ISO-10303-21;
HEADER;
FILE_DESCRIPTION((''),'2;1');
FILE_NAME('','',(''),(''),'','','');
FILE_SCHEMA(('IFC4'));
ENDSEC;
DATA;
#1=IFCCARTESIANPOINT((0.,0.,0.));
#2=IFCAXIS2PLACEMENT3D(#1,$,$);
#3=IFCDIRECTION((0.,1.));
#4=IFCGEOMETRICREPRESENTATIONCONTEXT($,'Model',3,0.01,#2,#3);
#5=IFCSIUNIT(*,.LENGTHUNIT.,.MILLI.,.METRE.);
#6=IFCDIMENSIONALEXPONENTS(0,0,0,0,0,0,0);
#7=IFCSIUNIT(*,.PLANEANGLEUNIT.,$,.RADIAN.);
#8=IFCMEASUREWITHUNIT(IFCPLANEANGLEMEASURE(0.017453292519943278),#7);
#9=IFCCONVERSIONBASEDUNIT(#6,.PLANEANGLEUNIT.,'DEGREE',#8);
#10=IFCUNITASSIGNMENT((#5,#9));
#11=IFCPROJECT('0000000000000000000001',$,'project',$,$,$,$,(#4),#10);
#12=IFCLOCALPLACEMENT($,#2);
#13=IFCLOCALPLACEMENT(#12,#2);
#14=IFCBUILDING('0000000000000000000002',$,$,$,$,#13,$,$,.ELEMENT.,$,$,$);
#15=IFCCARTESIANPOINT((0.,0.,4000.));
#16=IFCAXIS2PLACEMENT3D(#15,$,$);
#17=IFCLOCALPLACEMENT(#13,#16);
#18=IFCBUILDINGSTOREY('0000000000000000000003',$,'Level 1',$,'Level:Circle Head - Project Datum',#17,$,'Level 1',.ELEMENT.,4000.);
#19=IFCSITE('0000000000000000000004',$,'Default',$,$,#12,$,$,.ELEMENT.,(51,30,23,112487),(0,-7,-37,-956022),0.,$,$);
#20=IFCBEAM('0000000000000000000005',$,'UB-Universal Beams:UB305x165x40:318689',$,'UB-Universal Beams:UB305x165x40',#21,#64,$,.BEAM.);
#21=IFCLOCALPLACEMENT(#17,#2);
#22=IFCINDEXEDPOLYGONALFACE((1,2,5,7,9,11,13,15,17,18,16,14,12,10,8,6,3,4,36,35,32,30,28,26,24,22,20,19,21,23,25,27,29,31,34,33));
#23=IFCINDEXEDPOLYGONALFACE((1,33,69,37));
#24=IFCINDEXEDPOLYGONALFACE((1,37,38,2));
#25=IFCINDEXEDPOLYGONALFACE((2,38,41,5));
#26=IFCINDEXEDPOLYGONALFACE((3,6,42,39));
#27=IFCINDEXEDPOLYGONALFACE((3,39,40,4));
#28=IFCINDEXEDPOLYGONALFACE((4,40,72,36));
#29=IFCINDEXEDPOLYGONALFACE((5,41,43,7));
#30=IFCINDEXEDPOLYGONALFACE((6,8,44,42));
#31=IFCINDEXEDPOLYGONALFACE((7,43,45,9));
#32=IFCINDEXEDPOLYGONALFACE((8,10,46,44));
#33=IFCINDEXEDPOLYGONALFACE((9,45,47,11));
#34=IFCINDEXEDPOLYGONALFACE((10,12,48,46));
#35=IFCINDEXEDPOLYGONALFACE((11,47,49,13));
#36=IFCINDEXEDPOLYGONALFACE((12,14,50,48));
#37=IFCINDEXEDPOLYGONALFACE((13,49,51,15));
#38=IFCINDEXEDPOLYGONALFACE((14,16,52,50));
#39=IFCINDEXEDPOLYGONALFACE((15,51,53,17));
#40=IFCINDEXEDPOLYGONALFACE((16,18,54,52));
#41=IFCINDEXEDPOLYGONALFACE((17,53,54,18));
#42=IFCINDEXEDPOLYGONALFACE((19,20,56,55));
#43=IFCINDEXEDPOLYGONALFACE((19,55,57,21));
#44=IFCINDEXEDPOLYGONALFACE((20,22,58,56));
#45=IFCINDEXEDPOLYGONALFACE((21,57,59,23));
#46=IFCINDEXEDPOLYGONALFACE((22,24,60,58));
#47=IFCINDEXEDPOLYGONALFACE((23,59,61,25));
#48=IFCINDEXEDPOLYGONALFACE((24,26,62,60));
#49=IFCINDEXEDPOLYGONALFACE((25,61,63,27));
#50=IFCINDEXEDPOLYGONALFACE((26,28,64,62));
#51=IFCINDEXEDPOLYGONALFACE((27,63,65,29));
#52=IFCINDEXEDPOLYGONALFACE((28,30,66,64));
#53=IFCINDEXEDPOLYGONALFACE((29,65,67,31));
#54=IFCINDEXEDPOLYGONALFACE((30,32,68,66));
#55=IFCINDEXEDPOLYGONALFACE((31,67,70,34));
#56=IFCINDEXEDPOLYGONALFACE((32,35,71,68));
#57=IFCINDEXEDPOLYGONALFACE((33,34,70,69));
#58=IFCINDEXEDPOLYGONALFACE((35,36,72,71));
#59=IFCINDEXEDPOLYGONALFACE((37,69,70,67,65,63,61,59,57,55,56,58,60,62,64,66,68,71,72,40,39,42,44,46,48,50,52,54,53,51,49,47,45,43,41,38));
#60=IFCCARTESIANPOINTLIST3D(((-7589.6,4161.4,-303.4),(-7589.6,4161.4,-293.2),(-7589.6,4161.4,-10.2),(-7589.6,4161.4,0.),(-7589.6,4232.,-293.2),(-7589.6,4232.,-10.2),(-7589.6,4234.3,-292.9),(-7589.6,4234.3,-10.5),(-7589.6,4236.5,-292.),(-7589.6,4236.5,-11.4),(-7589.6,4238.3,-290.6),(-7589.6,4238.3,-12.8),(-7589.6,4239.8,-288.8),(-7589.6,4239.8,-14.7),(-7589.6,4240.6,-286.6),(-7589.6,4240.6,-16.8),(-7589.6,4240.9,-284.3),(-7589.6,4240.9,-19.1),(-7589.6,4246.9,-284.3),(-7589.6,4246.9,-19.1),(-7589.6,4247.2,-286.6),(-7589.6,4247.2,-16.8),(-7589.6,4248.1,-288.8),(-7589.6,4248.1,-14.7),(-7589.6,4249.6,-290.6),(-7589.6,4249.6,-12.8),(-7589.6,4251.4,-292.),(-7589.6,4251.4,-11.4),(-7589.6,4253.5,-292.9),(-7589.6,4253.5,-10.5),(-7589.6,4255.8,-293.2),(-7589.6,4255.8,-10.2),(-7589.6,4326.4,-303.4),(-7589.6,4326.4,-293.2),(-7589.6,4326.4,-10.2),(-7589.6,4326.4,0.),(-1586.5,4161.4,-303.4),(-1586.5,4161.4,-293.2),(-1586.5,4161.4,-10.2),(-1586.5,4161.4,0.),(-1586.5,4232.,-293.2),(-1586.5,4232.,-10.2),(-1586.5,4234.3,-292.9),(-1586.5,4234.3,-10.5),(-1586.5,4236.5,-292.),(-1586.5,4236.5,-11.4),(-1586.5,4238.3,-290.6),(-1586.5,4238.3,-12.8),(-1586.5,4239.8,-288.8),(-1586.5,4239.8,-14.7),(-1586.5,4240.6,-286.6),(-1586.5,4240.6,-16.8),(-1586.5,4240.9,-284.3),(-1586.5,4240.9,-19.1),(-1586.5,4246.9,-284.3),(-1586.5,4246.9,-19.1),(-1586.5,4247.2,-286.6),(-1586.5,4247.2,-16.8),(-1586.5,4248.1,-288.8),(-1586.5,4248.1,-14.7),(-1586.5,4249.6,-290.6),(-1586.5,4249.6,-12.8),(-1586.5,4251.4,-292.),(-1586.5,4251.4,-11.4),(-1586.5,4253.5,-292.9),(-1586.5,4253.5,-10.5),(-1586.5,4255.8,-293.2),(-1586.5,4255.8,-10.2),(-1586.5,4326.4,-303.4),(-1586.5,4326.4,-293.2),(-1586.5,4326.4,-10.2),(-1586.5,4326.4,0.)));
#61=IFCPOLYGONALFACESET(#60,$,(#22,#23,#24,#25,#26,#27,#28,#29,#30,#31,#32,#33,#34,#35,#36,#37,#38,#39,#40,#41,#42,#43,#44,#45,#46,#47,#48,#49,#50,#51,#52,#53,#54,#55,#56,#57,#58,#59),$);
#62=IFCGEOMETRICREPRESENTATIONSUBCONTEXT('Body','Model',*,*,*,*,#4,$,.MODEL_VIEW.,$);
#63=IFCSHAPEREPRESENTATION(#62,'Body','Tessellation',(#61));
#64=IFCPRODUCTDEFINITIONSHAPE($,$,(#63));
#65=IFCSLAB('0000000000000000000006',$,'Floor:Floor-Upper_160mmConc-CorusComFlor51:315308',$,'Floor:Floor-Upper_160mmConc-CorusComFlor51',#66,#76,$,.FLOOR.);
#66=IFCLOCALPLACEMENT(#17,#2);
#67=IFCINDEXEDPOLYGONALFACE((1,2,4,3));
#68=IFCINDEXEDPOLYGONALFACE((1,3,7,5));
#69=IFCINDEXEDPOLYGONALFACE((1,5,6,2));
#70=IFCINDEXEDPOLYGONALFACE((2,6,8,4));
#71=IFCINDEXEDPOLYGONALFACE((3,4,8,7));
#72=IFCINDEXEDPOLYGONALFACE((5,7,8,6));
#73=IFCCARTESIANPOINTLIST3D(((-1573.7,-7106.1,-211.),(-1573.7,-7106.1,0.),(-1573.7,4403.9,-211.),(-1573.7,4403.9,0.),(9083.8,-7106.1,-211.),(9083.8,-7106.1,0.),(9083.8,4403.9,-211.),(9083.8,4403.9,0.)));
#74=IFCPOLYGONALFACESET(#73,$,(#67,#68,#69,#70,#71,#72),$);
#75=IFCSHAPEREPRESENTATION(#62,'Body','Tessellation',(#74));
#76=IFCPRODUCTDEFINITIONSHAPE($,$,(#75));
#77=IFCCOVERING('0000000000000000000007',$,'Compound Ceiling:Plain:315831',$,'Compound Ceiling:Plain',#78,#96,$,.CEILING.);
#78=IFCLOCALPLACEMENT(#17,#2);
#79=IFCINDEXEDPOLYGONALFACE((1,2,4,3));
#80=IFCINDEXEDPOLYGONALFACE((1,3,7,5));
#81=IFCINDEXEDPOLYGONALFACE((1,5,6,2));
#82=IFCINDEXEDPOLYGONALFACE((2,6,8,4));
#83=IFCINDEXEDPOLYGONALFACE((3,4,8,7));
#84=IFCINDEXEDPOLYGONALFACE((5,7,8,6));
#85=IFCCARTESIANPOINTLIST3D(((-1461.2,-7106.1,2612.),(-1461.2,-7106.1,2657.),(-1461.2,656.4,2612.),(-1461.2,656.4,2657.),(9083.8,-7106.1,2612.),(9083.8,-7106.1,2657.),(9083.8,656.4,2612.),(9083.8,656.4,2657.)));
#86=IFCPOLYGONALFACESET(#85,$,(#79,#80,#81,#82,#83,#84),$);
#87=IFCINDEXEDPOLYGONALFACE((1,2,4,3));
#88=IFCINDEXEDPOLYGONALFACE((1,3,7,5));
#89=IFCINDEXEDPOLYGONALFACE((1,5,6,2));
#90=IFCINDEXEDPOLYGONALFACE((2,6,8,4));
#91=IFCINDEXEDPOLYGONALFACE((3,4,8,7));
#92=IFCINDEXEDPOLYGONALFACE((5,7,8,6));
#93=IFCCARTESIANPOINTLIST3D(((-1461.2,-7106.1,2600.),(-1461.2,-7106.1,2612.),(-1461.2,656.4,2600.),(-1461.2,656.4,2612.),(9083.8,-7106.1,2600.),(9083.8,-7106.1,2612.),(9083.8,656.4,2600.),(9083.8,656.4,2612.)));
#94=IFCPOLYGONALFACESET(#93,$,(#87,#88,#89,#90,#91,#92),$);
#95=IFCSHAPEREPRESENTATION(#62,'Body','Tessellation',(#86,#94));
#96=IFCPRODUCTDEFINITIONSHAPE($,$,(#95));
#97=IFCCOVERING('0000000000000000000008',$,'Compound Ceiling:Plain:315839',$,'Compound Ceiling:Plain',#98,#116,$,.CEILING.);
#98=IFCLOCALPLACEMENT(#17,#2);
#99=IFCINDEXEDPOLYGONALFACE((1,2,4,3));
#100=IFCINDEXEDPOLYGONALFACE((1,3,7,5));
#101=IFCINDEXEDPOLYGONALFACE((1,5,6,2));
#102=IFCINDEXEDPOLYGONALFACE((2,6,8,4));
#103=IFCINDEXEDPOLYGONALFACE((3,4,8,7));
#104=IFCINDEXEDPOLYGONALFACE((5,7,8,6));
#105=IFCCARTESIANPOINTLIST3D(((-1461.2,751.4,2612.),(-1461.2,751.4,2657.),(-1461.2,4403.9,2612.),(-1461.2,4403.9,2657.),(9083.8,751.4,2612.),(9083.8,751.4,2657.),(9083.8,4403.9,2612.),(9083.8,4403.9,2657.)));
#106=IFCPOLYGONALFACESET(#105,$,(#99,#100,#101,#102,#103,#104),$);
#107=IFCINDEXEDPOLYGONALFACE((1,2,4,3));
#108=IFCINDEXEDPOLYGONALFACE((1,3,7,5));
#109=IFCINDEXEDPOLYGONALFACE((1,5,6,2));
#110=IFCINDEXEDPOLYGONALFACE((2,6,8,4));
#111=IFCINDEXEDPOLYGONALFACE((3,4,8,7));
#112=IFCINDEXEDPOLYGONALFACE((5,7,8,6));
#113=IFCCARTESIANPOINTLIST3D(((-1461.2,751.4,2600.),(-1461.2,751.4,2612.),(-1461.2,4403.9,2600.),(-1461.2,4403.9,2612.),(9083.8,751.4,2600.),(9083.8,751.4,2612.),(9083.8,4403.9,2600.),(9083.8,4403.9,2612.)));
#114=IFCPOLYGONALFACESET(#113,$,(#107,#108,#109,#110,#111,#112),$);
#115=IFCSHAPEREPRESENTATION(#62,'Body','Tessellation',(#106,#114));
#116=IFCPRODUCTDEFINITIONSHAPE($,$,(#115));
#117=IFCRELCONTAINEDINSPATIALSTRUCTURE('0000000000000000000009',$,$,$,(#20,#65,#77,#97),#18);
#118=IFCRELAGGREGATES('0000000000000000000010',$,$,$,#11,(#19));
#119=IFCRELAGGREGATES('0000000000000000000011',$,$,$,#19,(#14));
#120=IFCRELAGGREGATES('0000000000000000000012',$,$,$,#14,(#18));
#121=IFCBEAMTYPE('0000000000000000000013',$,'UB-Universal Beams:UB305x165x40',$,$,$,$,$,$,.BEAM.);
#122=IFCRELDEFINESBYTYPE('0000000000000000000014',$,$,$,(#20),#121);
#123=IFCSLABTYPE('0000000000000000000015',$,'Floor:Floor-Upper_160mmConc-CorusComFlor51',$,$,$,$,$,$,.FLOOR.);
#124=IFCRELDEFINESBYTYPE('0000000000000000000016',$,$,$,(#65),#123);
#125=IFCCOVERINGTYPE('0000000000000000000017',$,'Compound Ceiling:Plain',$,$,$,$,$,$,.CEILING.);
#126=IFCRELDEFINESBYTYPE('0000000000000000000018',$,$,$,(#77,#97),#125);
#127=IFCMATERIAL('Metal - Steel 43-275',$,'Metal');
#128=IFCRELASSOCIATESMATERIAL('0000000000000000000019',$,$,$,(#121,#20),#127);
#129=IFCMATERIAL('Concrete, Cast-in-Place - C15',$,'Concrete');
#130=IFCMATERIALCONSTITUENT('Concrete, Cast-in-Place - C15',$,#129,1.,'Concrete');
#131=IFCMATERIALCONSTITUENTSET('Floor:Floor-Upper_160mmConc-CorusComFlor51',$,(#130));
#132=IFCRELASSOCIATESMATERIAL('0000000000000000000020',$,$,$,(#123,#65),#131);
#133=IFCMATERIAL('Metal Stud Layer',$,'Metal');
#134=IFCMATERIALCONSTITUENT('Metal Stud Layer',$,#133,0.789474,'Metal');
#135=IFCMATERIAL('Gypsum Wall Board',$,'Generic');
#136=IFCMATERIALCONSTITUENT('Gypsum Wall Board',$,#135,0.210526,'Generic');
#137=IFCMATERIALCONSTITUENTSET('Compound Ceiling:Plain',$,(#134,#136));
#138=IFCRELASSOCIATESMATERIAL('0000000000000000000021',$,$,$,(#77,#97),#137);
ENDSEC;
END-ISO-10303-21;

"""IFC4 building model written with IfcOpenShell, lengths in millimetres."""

from ifc_helpers import new_model, entity, si_unit, converted_unit, direction, frame, origin, place, context, subcontext, project, spatial, line, arc, indexed_curve, outline, extrude, source, transform, mapped, material, constituent, constituent_set, type_object, type_shapes, element, save


model = new_model("IFC4")

# Units and contexts
model_context = context("Model", 3, precision=0.01, world=origin(), true_north=direction((0.0, 1.0)))
body_context = subcontext(model_context, "Body", "Model", "MODEL_VIEW")
ifc_project = project(units=[si_unit("LENGTHUNIT", "METRE", prefix="MILLI"), converted_unit("PLANEANGLEUNIT", "DEGREE", entity("IfcPlaneAngleMeasure", 0.017453292519943278), si_unit("PLANEANGLEUNIT", "RADIAN"), dimensions=[0, 0, 0, 0, 0, 0, 0])], contexts=[model_context])

# Site, building, storey
site_placement = place(None, origin())
site = spatial("IfcSite", under=ifc_project, at=site_placement, Name="Default", CompositionType="ELEMENT", RefLatitude=(51, 30, 23, 112487), RefLongitude=(0, -7, -37, -956022), RefElevation=0.0)
building_placement = place(site_placement, origin())
building = spatial("IfcBuilding", under=site, at=building_placement, CompositionType="ELEMENT")
storey_placement = place(building_placement, frame((0.0, 0.0, 4000.0)))
storey = spatial("IfcBuildingStorey", under=building, at=storey_placement, Name="Level 1", ObjectType="Level:Circle Head - Project Datum", LongName="Level 1", CompositionType="ELEMENT", Elevation=4000.0)

# Shared definitions
ifc_material_1 = material(Name="Metal - Steel 43-275", Category="Metal")

# Beam
beam_type_1 = type_object("IfcBeamType", Name="UB-Universal Beams:UB305x165x40", PredefinedType="BEAM", material=ifc_material_1)
shared_shape_1 = source(origin(), body_context, "Body", "SweptSolid", [
    extrude(outline(indexed_curve([(-82.5, -141.5), (-82.5, -151.7), (82.5, -151.7), (82.5, -141.5), (11.9, -141.5), (5.6, -138.9), (3.0, -132.6), (3.0, 132.6), (5.6, 138.9), (11.9, 141.5), (82.5, 141.5), (82.5, 151.7), (-82.5, 151.7), (-82.5, 141.5), (-11.9, 141.5), (-5.6, 138.9), (-3.0, 132.6), (-3.0, -132.6), (-5.6, -138.9), (-11.9, -141.5)], segments=[line(1, 2, 3, 4, 5), arc(5, 6, 7), line(7, 8), arc(8, 9, 10), line(10, 11, 12, 13, 14, 15), arc(15, 16, 17), line(17, 18), arc(18, 19, 20), line(20, 1)], self_intersect=False)), frame((-2871.4, 0.0, 0.0), z_axis=(-1.0, 0.0, 0.0), x_axis=(0.0, -1.0, 0.0)), (0.0, 0.0, -1.0), 6003.1),
])
type_shapes(beam_type_1, [shared_shape_1])
beam_1_placement = place(storey_placement, frame((-4718.2, 4243.9, -151.7)))
element("IfcBeam", 1, at=beam_1_placement, inside=storey, type_object=beam_type_1, material=ifc_material_1, Name="UB-Universal Beams:UB305x165x40:318689", ObjectType="UB-Universal Beams:UB305x165x40", PredefinedType="BEAM", context=body_context, shape_type="MappedRepresentation", body=[
    mapped(shared_shape_1, transform((0.0, 0.0, 0.0), scale=1.0)),
])

# Slab
ifc_material_2 = material(Name="Concrete, Cast-in-Place - C15", Category="Concrete")
ifc_constituent_1 = constituent(ifc_material_2, Name="Concrete, Cast-in-Place - C15", Category="Concrete", fraction=1.0)
ifc_constituent_set_1 = constituent_set(constituents=[ifc_constituent_1], Name="Floor:Floor-Upper_160mmConc-CorusComFlor51")
slab_type = type_object("IfcSlabType", Name="Floor:Floor-Upper_160mmConc-CorusComFlor51", PredefinedType="FLOOR", material=ifc_constituent_set_1)
slab_placement = place(storey_placement, origin())
element("IfcSlab", 2, at=slab_placement, inside=storey, type_object=slab_type, material=ifc_constituent_set_1, Name="Floor:Floor-Upper_160mmConc-CorusComFlor51:315308", ObjectType="Floor:Floor-Upper_160mmConc-CorusComFlor51", PredefinedType="FLOOR", context=body_context, shape_type="SweptSolid", body=[
    extrude(outline(indexed_curve([(-5755.0, -5328.7), (5755.0, -5328.7), (5755.0, 5328.7), (-5755.0, 5328.7), (-5755.0, -5328.7)], self_intersect=False)), frame((3755.0, -1351.1, 0.0), z_axis=(0.0, 0.0, -1.0), x_axis=(0.0, 1.0, 0.0)), (0.0, 0.0, 1.0), 211.0),
])

# Shared definitions
ifc_material_3 = material(Name="Gypsum Wall Board", Category="Generic")
ifc_material_4 = material(Name="Metal Stud Layer", Category="Metal")

# Coverings
ifc_constituent_2 = constituent(ifc_material_4, Name="Metal Stud Layer", Category="Metal", fraction=0.789474)
ifc_constituent_3 = constituent(ifc_material_3, Name="Gypsum Wall Board", Category="Generic", fraction=0.210526)
ifc_constituent_set_2 = constituent_set(constituents=[ifc_constituent_2, ifc_constituent_3], Name="Compound Ceiling:Plain")
covering_type = type_object("IfcCoveringType", Name="Compound Ceiling:Plain", PredefinedType="CEILING")
covering_1_placement = place(storey_placement, origin())
element("IfcCovering", 3, at=covering_1_placement, inside=storey, type_object=covering_type, material=ifc_constituent_set_2, Name="Compound Ceiling:Plain:315831", ObjectType="Compound Ceiling:Plain", PredefinedType="CEILING", context=body_context, shape_type="SweptSolid", body=[
    extrude(outline(indexed_curve([(-3881.2, -5272.5), (3881.2, -5272.5), (3881.2, 5272.5), (-3881.2, 5272.5), (-3881.2, -5272.5)], self_intersect=False)), frame((3811.3, -3224.8, 2612.0), z_axis=(0.0, 0.0, 1.0), x_axis=(0.0, -1.0, 0.0)), (0.0, 0.0, 1.0), 45.0),
    extrude(outline(indexed_curve([(-5272.5, -3881.2), (5272.5, -3881.2), (5272.5, 3881.3), (-5272.5, 3881.2), (-5272.5, -3881.2)], self_intersect=False)), frame((3811.3, -3224.8, 2600.0), z_axis=(0.0, 0.0, 1.0), x_axis=(-1.0, 0.0, 0.0)), (0.0, 0.0, 1.0), 12.0),
])
covering_2_placement = place(storey_placement, origin())
element("IfcCovering", 4, at=covering_2_placement, inside=storey, type_object=covering_type, material=ifc_constituent_set_2, Name="Compound Ceiling:Plain:315839", ObjectType="Compound Ceiling:Plain", PredefinedType="CEILING", context=body_context, shape_type="SweptSolid", body=[
    extrude(outline(indexed_curve([(-5272.5, -1826.3), (5272.5, -1826.3), (5272.5, 1826.3), (-5272.5, 1826.3), (-5272.5, -1826.3)], self_intersect=False)), frame((3811.3, 2577.7, 2612.0)), (0.0, 0.0, 1.0), 45.0),
    extrude(outline(indexed_curve([(-1826.3, -5272.5), (1826.2, -5272.5), (1826.3, 5272.5), (-1826.2, 5272.5), (-1826.3, -5272.5)], self_intersect=False)), frame((3811.3, 2577.7, 2600.0), z_axis=(0.0, 0.0, 1.0), x_axis=(0.0, -1.0, 0.0)), (0.0, 0.0, 1.0), 12.0),
])

save(model, "model.ifc")
